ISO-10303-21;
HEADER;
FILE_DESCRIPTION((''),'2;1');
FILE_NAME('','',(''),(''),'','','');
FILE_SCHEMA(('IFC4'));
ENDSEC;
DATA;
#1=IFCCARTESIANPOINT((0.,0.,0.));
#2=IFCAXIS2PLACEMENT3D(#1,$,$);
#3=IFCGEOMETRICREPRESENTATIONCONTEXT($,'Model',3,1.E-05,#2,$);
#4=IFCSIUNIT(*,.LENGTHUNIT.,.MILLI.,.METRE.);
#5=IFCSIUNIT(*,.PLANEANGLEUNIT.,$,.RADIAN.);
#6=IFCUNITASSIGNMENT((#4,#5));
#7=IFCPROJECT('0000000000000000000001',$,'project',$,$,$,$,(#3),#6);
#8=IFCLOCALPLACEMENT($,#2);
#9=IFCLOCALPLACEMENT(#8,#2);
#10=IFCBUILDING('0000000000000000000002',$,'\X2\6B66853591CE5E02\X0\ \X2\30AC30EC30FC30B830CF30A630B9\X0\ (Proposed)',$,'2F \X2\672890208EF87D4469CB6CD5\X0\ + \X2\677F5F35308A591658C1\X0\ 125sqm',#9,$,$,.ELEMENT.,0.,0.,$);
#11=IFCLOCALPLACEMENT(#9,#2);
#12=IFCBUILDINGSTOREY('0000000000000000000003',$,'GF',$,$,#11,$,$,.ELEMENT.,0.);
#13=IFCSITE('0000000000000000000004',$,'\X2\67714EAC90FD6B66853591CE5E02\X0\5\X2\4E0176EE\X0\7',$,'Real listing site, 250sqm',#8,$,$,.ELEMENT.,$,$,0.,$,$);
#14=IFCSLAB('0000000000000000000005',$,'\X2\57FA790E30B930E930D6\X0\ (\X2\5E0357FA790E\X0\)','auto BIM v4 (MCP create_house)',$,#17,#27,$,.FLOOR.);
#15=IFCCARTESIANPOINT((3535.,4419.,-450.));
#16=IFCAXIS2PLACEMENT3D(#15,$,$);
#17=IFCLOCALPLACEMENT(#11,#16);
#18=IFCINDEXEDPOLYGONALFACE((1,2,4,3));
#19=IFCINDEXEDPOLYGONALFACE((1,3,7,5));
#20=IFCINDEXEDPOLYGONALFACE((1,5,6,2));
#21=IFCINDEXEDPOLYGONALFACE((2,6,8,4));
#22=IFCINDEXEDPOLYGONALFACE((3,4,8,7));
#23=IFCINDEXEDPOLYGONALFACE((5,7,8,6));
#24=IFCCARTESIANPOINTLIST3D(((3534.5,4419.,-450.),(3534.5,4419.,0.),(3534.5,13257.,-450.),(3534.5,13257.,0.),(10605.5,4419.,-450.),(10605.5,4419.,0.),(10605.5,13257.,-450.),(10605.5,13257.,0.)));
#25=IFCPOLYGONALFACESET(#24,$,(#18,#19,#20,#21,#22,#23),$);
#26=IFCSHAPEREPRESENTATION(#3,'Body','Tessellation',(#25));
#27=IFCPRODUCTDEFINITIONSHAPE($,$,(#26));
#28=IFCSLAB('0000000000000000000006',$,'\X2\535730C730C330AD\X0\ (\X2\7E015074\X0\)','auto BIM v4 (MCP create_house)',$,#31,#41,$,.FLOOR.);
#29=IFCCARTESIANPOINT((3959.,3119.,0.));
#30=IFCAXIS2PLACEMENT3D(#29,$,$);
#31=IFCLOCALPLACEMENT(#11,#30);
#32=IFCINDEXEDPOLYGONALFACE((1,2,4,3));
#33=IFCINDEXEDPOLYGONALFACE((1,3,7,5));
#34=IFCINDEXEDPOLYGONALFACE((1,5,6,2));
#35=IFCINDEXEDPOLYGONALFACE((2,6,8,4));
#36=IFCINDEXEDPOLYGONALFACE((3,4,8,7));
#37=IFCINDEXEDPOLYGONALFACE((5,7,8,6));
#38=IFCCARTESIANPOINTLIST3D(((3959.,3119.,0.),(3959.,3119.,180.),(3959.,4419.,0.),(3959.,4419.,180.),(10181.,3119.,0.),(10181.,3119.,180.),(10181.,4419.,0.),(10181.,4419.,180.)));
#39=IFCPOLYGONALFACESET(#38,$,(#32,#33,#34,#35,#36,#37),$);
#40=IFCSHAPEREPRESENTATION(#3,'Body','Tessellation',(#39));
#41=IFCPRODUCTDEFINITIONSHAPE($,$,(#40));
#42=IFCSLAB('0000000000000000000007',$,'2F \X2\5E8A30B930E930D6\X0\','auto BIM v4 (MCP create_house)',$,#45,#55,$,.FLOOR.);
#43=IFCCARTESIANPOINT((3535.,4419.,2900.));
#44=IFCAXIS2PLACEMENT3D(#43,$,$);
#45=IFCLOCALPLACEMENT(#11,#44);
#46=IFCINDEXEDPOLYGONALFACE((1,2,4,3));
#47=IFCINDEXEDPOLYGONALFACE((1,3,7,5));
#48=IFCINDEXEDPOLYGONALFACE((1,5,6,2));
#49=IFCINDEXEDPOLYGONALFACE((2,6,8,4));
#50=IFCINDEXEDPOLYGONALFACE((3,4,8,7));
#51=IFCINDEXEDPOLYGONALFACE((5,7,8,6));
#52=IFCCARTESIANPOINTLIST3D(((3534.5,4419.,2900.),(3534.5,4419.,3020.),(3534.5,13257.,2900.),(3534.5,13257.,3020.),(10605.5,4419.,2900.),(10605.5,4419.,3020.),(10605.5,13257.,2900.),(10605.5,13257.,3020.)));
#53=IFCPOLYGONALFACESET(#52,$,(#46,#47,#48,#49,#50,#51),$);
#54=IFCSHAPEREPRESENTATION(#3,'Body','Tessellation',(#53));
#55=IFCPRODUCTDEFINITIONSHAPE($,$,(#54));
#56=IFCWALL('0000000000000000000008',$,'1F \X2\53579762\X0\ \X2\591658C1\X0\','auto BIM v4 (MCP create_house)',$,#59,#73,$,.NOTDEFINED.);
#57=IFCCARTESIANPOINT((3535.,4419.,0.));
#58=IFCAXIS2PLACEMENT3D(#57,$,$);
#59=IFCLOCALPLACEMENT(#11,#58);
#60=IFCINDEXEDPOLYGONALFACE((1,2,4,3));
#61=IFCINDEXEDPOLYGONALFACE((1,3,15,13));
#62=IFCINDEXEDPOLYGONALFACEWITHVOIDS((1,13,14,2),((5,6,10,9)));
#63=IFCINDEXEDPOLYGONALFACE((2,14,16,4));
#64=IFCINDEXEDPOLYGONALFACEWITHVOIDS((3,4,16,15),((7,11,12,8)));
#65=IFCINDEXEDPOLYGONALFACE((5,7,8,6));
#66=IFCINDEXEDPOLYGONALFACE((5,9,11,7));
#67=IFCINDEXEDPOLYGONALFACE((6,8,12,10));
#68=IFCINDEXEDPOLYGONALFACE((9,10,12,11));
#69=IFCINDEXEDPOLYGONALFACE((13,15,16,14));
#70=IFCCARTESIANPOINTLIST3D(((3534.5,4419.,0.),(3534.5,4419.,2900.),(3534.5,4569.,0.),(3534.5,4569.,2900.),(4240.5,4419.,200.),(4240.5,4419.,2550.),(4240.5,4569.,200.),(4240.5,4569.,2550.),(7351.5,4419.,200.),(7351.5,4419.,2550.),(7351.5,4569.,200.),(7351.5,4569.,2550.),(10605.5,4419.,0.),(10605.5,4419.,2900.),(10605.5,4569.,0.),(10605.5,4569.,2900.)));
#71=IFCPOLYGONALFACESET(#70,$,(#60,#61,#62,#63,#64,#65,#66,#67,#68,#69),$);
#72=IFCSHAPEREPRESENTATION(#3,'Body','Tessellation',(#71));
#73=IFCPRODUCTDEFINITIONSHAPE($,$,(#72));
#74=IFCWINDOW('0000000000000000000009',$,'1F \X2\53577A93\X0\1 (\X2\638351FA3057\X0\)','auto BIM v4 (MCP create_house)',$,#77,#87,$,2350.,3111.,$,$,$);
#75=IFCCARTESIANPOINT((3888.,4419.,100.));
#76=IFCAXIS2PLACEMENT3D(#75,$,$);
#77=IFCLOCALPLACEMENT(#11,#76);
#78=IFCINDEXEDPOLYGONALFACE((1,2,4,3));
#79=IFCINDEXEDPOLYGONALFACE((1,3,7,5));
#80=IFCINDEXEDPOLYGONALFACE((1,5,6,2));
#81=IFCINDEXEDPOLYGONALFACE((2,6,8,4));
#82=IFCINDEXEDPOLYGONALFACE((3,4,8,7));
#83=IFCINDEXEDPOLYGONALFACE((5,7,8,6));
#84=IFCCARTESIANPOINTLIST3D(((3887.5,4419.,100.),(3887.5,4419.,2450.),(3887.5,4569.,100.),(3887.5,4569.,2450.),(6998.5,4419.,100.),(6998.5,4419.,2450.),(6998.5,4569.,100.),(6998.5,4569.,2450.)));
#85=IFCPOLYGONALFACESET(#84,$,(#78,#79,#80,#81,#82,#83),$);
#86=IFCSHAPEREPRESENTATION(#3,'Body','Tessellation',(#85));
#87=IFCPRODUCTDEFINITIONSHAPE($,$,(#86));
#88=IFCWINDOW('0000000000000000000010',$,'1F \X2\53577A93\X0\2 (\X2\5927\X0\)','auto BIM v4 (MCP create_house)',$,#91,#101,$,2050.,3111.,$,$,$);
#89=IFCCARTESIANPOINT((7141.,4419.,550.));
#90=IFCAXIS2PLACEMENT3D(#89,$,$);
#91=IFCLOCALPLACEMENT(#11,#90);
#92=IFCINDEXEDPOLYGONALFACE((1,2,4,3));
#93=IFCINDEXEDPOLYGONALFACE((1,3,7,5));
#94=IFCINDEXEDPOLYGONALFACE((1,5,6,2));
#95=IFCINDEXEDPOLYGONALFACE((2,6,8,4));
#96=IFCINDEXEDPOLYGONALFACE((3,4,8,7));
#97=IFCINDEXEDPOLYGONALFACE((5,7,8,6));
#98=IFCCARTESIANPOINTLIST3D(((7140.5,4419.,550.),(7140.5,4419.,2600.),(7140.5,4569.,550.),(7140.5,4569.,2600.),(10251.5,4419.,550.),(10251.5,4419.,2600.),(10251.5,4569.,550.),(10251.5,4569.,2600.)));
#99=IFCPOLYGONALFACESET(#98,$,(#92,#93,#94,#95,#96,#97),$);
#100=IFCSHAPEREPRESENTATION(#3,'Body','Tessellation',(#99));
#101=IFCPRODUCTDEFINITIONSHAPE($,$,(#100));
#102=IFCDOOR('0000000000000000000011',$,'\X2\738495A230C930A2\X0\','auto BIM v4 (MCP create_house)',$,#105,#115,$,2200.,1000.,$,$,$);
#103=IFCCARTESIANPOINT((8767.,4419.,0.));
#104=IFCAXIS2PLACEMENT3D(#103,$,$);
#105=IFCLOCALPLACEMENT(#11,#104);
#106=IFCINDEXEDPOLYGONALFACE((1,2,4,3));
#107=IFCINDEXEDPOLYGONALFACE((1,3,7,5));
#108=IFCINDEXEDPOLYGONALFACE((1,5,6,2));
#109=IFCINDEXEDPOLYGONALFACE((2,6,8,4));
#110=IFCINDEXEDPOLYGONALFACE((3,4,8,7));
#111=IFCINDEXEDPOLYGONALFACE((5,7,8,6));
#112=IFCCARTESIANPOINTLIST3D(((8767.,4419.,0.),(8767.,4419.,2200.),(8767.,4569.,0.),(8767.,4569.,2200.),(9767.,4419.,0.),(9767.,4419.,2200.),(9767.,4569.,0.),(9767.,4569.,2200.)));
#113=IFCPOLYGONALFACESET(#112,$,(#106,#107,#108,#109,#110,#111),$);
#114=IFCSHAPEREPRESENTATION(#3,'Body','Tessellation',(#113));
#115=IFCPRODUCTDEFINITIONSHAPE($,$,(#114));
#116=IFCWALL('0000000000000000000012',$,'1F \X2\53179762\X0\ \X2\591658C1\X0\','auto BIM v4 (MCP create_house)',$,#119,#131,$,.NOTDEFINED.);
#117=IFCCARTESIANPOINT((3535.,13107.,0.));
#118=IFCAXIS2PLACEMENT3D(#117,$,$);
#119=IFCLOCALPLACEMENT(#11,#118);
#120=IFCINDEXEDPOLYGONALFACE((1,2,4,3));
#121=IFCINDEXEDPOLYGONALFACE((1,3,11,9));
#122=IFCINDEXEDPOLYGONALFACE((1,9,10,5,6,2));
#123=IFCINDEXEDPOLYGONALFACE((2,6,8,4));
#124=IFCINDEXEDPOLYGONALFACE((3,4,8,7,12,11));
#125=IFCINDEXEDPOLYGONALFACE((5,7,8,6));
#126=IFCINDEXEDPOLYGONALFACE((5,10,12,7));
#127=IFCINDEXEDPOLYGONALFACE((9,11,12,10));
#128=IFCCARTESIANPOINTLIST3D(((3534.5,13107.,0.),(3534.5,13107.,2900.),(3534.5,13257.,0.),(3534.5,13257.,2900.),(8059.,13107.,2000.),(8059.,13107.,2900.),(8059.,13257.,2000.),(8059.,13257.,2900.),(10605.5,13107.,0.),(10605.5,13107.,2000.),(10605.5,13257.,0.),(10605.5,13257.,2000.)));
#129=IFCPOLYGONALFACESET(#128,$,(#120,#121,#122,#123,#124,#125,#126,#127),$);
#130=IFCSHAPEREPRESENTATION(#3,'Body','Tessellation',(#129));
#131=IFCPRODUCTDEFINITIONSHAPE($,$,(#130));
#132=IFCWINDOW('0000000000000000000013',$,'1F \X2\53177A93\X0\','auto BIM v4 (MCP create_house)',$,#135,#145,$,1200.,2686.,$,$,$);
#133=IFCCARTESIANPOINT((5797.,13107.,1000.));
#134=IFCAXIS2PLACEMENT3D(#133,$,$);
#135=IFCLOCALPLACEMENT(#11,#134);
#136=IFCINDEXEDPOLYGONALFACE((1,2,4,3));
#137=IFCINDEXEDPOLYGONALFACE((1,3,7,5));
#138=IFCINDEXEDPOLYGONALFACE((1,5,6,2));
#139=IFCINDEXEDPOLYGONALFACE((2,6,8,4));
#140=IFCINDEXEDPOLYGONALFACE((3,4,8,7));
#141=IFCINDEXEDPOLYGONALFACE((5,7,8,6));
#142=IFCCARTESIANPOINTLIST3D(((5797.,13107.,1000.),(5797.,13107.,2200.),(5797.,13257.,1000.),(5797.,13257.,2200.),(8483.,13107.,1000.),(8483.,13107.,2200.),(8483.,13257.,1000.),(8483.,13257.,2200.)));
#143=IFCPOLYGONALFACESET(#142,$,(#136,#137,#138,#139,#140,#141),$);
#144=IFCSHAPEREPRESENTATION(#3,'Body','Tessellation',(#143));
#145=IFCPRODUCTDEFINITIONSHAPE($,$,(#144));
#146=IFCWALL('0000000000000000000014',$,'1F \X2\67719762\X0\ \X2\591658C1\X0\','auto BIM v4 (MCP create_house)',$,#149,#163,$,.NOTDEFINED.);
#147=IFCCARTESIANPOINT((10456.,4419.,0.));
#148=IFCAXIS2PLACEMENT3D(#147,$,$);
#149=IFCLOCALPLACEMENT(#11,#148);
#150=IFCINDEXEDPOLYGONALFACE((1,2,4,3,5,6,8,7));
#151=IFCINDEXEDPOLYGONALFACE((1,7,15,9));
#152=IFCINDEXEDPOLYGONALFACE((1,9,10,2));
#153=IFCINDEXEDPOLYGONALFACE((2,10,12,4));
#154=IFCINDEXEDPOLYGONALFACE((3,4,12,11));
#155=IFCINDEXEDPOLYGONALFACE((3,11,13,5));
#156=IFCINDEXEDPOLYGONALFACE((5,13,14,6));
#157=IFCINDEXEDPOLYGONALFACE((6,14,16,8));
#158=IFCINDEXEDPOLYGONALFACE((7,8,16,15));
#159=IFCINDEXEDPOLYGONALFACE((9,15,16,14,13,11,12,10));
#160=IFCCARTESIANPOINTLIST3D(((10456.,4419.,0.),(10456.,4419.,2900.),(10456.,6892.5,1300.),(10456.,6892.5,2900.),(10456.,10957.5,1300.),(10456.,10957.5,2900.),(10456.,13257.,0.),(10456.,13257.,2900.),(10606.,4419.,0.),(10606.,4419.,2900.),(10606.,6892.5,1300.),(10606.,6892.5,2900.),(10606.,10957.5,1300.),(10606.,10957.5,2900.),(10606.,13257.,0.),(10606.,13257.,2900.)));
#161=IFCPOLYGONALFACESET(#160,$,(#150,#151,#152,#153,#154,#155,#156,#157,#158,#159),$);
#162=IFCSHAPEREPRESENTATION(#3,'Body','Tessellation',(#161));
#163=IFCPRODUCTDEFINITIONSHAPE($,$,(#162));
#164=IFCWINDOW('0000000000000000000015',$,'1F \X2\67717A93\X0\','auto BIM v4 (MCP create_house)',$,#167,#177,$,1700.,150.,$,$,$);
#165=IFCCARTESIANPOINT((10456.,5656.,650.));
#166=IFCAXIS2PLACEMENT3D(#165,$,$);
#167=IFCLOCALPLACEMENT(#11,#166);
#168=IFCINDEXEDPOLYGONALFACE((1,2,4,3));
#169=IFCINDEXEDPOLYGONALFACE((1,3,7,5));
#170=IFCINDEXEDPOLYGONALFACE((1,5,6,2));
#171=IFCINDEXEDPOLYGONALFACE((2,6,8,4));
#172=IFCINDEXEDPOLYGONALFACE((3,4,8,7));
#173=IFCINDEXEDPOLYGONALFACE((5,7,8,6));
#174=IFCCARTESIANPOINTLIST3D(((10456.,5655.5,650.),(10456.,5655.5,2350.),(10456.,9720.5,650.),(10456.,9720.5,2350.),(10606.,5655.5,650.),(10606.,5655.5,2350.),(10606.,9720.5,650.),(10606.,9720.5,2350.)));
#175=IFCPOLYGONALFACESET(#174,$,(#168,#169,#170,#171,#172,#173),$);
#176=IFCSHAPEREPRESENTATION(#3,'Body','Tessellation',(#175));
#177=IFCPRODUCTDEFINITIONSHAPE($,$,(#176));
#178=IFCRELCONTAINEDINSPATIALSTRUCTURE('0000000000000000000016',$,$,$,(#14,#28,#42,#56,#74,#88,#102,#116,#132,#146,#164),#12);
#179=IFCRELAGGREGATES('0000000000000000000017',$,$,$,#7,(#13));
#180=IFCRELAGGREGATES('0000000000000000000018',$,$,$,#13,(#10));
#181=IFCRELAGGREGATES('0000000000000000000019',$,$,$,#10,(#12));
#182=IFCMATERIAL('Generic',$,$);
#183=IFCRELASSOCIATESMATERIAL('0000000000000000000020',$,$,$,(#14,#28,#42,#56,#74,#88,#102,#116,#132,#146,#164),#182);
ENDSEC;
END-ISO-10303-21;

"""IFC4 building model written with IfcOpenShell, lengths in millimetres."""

from ifc_helpers import new_model, si_unit, frame, frame_2d, origin, place, context, project, spatial, rectangle, extrude, material, element, fill, save


model = new_model("IFC4")

# Units and contexts
model_context = context("Model", 3, precision=1e-05, world=origin())
ifc_project = project(units=[si_unit("LENGTHUNIT", "METRE", prefix="MILLI"), si_unit("PLANEANGLEUNIT", "RADIAN")], contexts=[model_context])

# Site, building, storey
site_placement = place(None, origin())
site = spatial("IfcSite", under=ifc_project, at=site_placement, Name="東京都武蔵野市5丁目7", ObjectType="Real listing site, 250sqm", CompositionType="ELEMENT", RefElevation=0.0)
building_placement = place(site_placement, origin())
building = spatial("IfcBuilding", under=site, at=building_placement, Name="武蔵野市 ガレージハウス (Proposed)", ObjectType="2F 木造軸組構法 + 板張り外壁 125sqm", CompositionType="ELEMENT", ElevationOfRefHeight=0.0, ElevationOfTerrain=0.0)
storey_placement = place(building_placement, origin())
storey = spatial("IfcBuildingStorey", under=building, at=storey_placement, Name="GF", CompositionType="ELEMENT", Elevation=0.0)

# Slabs
ifc_material = material(Name="Generic")
slab_1_placement = place(storey_placement, frame((3535.0, 4419.0, -450.0)))
element("IfcSlab", 1, at=slab_1_placement, inside=storey, material=ifc_material, Name="基礎スラブ (布基礎)", Description="auto BIM v4 (MCP create_house)", PredefinedType="FLOOR", context=model_context, shape_type="SweptSolid", body=[
    extrude(rectangle(XDim=7071.0, YDim=8838.0, at=frame_2d((3535.0, 4419.0))), frame((3535.0, 4419.0, -450.0)), (0.0, 0.0, 1.0), 450.0),
])
slab_2_placement = place(storey_placement, frame((3959.0, 3119.0, 0.0)))
element("IfcSlab", 2, at=slab_2_placement, inside=storey, material=ifc_material, Name="南デッキ (縁側)", Description="auto BIM v4 (MCP create_house)", PredefinedType="FLOOR", context=model_context, shape_type="SweptSolid", body=[
    extrude(rectangle(XDim=6222.0, YDim=1300.0, at=frame_2d((3111.0, 650.0))), frame((3959.0, 3119.0, 0.0)), (0.0, 0.0, 1.0), 180.0),
])
slab_3_placement = place(storey_placement, frame((3535.0, 4419.0, 2900.0)))
element("IfcSlab", 3, at=slab_3_placement, inside=storey, material=ifc_material, Name="2F 床スラブ", Description="auto BIM v4 (MCP create_house)", PredefinedType="FLOOR", context=model_context, shape_type="SweptSolid", body=[
    extrude(rectangle(XDim=7071.0, YDim=8838.0, at=frame_2d((3535.0, 4419.0))), frame((3535.0, 4419.0, 2900.0)), (0.0, 0.0, 1.0), 120.0),
])

# Wall, openings, windows, door
wall_1_placement = place(storey_placement, frame((3535.0, 4419.0, 0.0)))
wall_1 = element("IfcWall", 4, at=wall_1_placement, inside=storey, material=ifc_material, Name="1F 南面 外壁", Description="auto BIM v4 (MCP create_house)", PredefinedType="NOTDEFINED", context=model_context, shape_type="SweptSolid", body=[
    extrude(rectangle(XDim=7071.0, YDim=150.0, at=frame_2d((3535.0, 75.0))), frame((3535.0, 4419.0, 0.0)), (0.0, 0.0, 1.0), 2900.0),
])
opening_1_placement = place(storey_placement, frame((3888.0, 4419.0, 100.0)))
opening_1 = element("IfcOpeningElement", 5, at=opening_1_placement, cuts=wall_1, PredefinedType="NOTDEFINED", context=model_context, shape_type="SweptSolid", body=[
    extrude(rectangle(XDim=3111.0, YDim=150.0, at=frame_2d((1555.0, 75.0))), frame((3888.0, 4419.0, 100.0)), (0.0, 0.0, 1.0), 2350.0),
])
opening_2_placement = place(storey_placement, frame((7141.0, 4419.0, 550.0)))
opening_2 = element("IfcOpeningElement", 6, at=opening_2_placement, cuts=wall_1, PredefinedType="NOTDEFINED", context=model_context, shape_type="SweptSolid", body=[
    extrude(rectangle(XDim=3111.0, YDim=150.0, at=frame_2d((1555.0, 75.0))), frame((7141.0, 4419.0, 550.0)), (0.0, 0.0, 1.0), 2050.0),
])
opening_3_placement = place(storey_placement, frame((8767.0, 4419.0, 0.0)))
opening_3 = element("IfcOpeningElement", 7, at=opening_3_placement, cuts=wall_1, PredefinedType="NOTDEFINED", context=model_context, shape_type="SweptSolid", body=[
    extrude(rectangle(XDim=1000.0, YDim=150.0, at=frame_2d((500.0, 75.0))), frame((8767.0, 4419.0, 0.0)), (0.0, 0.0, 1.0), 2200.0),
])
window_1_placement = place(storey_placement, frame((3888.0, 4419.0, 100.0)))
window_1 = element("IfcWindow", 8, at=window_1_placement, inside=storey, material=ifc_material, Name="1F 南窓1 (掃出し)", Description="auto BIM v4 (MCP create_house)", OverallHeight=2350.0, OverallWidth=3111.0, context=model_context, shape_type="SweptSolid", body=[
    extrude(rectangle(XDim=3111.0, YDim=150.0, at=frame_2d((1555.0, 75.0))), frame((3888.0, 4419.0, 100.0)), (0.0, 0.0, 1.0), 2350.0),
])
fill(opening_1, window_1)
window_2_placement = place(storey_placement, frame((7141.0, 4419.0, 550.0)))
window_2 = element("IfcWindow", 9, at=window_2_placement, inside=storey, material=ifc_material, Name="1F 南窓2 (大)", Description="auto BIM v4 (MCP create_house)", OverallHeight=2050.0, OverallWidth=3111.0, context=model_context, shape_type="SweptSolid", body=[
    extrude(rectangle(XDim=3111.0, YDim=150.0, at=frame_2d((1555.0, 75.0))), frame((7141.0, 4419.0, 550.0)), (0.0, 0.0, 1.0), 2050.0),
])
fill(opening_2, window_2)
door_1_placement = place(storey_placement, frame((8767.0, 4419.0, 0.0)))
door_1 = element("IfcDoor", 10, at=door_1_placement, inside=storey, material=ifc_material, Name="玄関ドア", Description="auto BIM v4 (MCP create_house)", OverallHeight=2200.0, OverallWidth=1000.0, context=model_context, shape_type="SweptSolid", body=[
    extrude(rectangle(XDim=1000.0, YDim=150.0, at=frame_2d((500.0, 75.0))), frame((8767.0, 4419.0, 0.0)), (0.0, 0.0, 1.0), 2200.0),
])
fill(opening_3, door_1)

# Walls, openings, windows
wall_2_placement = place(storey_placement, frame((3535.0, 13107.0, 0.0)))
wall_2 = element("IfcWall", 11, at=wall_2_placement, inside=storey, material=ifc_material, Name="1F 北面 外壁", Description="auto BIM v4 (MCP create_house)", PredefinedType="NOTDEFINED", context=model_context, shape_type="SweptSolid", body=[
    extrude(rectangle(XDim=7071.0, YDim=150.0, at=frame_2d((3535.0, 75.0))), frame((3535.0, 13107.0, 0.0)), (0.0, 0.0, 1.0), 2900.0),
])
opening_4_placement = place(storey_placement, frame((5797.0, 13107.0, 1000.0)))
opening_4 = element("IfcOpeningElement", 12, at=opening_4_placement, cuts=wall_2, PredefinedType="NOTDEFINED", context=model_context, shape_type="SweptSolid", body=[
    extrude(rectangle(XDim=2686.0, YDim=150.0, at=frame_2d((1343.0, 75.0))), frame((5797.0, 13107.0, 1000.0)), (0.0, 0.0, 1.0), 1200.0),
])
window_3_placement = place(storey_placement, frame((5797.0, 13107.0, 1000.0)))
window_3 = element("IfcWindow", 13, at=window_3_placement, inside=storey, material=ifc_material, Name="1F 北窓", Description="auto BIM v4 (MCP create_house)", OverallHeight=1200.0, OverallWidth=2686.0, context=model_context, shape_type="SweptSolid", body=[
    extrude(rectangle(XDim=2686.0, YDim=150.0, at=frame_2d((1343.0, 75.0))), frame((5797.0, 13107.0, 1000.0)), (0.0, 0.0, 1.0), 1200.0),
])
fill(opening_4, window_3)
wall_3_placement = place(storey_placement, frame((10456.0, 4419.0, 0.0)))
wall_3 = element("IfcWall", 14, at=wall_3_placement, inside=storey, material=ifc_material, Name="1F 東面 外壁", Description="auto BIM v4 (MCP create_house)", PredefinedType="NOTDEFINED", context=model_context, shape_type="SweptSolid", body=[
    extrude(rectangle(XDim=150.0, YDim=8838.0, at=frame_2d((75.0, 4419.0))), frame((10456.0, 4419.0, 0.0)), (0.0, 0.0, 1.0), 2900.0),
])
opening_5_placement = place(storey_placement, frame((10456.0, 5656.0, 650.0)))
opening_5 = element("IfcOpeningElement", 15, at=opening_5_placement, cuts=wall_3, PredefinedType="NOTDEFINED", context=model_context, shape_type="SweptSolid", body=[
    extrude(rectangle(XDim=150.0, YDim=4065.0, at=frame_2d((75.0, 2032.0))), frame((10456.0, 5656.0, 650.0)), (0.0, 0.0, 1.0), 1700.0),
])
window_4_placement = place(storey_placement, frame((10456.0, 5656.0, 650.0)))
window_4 = element("IfcWindow", 16, at=window_4_placement, inside=storey, material=ifc_material, Name="1F 東窓", Description="auto BIM v4 (MCP create_house)", OverallHeight=1700.0, OverallWidth=150.0, context=model_context, shape_type="SweptSolid", body=[
    extrude(rectangle(XDim=150.0, YDim=4065.0, at=frame_2d((75.0, 2032.0))), frame((10456.0, 5656.0, 650.0)), (0.0, 0.0, 1.0), 1700.0),
])
fill(opening_5, window_4)

save(model, "model.ifc")
